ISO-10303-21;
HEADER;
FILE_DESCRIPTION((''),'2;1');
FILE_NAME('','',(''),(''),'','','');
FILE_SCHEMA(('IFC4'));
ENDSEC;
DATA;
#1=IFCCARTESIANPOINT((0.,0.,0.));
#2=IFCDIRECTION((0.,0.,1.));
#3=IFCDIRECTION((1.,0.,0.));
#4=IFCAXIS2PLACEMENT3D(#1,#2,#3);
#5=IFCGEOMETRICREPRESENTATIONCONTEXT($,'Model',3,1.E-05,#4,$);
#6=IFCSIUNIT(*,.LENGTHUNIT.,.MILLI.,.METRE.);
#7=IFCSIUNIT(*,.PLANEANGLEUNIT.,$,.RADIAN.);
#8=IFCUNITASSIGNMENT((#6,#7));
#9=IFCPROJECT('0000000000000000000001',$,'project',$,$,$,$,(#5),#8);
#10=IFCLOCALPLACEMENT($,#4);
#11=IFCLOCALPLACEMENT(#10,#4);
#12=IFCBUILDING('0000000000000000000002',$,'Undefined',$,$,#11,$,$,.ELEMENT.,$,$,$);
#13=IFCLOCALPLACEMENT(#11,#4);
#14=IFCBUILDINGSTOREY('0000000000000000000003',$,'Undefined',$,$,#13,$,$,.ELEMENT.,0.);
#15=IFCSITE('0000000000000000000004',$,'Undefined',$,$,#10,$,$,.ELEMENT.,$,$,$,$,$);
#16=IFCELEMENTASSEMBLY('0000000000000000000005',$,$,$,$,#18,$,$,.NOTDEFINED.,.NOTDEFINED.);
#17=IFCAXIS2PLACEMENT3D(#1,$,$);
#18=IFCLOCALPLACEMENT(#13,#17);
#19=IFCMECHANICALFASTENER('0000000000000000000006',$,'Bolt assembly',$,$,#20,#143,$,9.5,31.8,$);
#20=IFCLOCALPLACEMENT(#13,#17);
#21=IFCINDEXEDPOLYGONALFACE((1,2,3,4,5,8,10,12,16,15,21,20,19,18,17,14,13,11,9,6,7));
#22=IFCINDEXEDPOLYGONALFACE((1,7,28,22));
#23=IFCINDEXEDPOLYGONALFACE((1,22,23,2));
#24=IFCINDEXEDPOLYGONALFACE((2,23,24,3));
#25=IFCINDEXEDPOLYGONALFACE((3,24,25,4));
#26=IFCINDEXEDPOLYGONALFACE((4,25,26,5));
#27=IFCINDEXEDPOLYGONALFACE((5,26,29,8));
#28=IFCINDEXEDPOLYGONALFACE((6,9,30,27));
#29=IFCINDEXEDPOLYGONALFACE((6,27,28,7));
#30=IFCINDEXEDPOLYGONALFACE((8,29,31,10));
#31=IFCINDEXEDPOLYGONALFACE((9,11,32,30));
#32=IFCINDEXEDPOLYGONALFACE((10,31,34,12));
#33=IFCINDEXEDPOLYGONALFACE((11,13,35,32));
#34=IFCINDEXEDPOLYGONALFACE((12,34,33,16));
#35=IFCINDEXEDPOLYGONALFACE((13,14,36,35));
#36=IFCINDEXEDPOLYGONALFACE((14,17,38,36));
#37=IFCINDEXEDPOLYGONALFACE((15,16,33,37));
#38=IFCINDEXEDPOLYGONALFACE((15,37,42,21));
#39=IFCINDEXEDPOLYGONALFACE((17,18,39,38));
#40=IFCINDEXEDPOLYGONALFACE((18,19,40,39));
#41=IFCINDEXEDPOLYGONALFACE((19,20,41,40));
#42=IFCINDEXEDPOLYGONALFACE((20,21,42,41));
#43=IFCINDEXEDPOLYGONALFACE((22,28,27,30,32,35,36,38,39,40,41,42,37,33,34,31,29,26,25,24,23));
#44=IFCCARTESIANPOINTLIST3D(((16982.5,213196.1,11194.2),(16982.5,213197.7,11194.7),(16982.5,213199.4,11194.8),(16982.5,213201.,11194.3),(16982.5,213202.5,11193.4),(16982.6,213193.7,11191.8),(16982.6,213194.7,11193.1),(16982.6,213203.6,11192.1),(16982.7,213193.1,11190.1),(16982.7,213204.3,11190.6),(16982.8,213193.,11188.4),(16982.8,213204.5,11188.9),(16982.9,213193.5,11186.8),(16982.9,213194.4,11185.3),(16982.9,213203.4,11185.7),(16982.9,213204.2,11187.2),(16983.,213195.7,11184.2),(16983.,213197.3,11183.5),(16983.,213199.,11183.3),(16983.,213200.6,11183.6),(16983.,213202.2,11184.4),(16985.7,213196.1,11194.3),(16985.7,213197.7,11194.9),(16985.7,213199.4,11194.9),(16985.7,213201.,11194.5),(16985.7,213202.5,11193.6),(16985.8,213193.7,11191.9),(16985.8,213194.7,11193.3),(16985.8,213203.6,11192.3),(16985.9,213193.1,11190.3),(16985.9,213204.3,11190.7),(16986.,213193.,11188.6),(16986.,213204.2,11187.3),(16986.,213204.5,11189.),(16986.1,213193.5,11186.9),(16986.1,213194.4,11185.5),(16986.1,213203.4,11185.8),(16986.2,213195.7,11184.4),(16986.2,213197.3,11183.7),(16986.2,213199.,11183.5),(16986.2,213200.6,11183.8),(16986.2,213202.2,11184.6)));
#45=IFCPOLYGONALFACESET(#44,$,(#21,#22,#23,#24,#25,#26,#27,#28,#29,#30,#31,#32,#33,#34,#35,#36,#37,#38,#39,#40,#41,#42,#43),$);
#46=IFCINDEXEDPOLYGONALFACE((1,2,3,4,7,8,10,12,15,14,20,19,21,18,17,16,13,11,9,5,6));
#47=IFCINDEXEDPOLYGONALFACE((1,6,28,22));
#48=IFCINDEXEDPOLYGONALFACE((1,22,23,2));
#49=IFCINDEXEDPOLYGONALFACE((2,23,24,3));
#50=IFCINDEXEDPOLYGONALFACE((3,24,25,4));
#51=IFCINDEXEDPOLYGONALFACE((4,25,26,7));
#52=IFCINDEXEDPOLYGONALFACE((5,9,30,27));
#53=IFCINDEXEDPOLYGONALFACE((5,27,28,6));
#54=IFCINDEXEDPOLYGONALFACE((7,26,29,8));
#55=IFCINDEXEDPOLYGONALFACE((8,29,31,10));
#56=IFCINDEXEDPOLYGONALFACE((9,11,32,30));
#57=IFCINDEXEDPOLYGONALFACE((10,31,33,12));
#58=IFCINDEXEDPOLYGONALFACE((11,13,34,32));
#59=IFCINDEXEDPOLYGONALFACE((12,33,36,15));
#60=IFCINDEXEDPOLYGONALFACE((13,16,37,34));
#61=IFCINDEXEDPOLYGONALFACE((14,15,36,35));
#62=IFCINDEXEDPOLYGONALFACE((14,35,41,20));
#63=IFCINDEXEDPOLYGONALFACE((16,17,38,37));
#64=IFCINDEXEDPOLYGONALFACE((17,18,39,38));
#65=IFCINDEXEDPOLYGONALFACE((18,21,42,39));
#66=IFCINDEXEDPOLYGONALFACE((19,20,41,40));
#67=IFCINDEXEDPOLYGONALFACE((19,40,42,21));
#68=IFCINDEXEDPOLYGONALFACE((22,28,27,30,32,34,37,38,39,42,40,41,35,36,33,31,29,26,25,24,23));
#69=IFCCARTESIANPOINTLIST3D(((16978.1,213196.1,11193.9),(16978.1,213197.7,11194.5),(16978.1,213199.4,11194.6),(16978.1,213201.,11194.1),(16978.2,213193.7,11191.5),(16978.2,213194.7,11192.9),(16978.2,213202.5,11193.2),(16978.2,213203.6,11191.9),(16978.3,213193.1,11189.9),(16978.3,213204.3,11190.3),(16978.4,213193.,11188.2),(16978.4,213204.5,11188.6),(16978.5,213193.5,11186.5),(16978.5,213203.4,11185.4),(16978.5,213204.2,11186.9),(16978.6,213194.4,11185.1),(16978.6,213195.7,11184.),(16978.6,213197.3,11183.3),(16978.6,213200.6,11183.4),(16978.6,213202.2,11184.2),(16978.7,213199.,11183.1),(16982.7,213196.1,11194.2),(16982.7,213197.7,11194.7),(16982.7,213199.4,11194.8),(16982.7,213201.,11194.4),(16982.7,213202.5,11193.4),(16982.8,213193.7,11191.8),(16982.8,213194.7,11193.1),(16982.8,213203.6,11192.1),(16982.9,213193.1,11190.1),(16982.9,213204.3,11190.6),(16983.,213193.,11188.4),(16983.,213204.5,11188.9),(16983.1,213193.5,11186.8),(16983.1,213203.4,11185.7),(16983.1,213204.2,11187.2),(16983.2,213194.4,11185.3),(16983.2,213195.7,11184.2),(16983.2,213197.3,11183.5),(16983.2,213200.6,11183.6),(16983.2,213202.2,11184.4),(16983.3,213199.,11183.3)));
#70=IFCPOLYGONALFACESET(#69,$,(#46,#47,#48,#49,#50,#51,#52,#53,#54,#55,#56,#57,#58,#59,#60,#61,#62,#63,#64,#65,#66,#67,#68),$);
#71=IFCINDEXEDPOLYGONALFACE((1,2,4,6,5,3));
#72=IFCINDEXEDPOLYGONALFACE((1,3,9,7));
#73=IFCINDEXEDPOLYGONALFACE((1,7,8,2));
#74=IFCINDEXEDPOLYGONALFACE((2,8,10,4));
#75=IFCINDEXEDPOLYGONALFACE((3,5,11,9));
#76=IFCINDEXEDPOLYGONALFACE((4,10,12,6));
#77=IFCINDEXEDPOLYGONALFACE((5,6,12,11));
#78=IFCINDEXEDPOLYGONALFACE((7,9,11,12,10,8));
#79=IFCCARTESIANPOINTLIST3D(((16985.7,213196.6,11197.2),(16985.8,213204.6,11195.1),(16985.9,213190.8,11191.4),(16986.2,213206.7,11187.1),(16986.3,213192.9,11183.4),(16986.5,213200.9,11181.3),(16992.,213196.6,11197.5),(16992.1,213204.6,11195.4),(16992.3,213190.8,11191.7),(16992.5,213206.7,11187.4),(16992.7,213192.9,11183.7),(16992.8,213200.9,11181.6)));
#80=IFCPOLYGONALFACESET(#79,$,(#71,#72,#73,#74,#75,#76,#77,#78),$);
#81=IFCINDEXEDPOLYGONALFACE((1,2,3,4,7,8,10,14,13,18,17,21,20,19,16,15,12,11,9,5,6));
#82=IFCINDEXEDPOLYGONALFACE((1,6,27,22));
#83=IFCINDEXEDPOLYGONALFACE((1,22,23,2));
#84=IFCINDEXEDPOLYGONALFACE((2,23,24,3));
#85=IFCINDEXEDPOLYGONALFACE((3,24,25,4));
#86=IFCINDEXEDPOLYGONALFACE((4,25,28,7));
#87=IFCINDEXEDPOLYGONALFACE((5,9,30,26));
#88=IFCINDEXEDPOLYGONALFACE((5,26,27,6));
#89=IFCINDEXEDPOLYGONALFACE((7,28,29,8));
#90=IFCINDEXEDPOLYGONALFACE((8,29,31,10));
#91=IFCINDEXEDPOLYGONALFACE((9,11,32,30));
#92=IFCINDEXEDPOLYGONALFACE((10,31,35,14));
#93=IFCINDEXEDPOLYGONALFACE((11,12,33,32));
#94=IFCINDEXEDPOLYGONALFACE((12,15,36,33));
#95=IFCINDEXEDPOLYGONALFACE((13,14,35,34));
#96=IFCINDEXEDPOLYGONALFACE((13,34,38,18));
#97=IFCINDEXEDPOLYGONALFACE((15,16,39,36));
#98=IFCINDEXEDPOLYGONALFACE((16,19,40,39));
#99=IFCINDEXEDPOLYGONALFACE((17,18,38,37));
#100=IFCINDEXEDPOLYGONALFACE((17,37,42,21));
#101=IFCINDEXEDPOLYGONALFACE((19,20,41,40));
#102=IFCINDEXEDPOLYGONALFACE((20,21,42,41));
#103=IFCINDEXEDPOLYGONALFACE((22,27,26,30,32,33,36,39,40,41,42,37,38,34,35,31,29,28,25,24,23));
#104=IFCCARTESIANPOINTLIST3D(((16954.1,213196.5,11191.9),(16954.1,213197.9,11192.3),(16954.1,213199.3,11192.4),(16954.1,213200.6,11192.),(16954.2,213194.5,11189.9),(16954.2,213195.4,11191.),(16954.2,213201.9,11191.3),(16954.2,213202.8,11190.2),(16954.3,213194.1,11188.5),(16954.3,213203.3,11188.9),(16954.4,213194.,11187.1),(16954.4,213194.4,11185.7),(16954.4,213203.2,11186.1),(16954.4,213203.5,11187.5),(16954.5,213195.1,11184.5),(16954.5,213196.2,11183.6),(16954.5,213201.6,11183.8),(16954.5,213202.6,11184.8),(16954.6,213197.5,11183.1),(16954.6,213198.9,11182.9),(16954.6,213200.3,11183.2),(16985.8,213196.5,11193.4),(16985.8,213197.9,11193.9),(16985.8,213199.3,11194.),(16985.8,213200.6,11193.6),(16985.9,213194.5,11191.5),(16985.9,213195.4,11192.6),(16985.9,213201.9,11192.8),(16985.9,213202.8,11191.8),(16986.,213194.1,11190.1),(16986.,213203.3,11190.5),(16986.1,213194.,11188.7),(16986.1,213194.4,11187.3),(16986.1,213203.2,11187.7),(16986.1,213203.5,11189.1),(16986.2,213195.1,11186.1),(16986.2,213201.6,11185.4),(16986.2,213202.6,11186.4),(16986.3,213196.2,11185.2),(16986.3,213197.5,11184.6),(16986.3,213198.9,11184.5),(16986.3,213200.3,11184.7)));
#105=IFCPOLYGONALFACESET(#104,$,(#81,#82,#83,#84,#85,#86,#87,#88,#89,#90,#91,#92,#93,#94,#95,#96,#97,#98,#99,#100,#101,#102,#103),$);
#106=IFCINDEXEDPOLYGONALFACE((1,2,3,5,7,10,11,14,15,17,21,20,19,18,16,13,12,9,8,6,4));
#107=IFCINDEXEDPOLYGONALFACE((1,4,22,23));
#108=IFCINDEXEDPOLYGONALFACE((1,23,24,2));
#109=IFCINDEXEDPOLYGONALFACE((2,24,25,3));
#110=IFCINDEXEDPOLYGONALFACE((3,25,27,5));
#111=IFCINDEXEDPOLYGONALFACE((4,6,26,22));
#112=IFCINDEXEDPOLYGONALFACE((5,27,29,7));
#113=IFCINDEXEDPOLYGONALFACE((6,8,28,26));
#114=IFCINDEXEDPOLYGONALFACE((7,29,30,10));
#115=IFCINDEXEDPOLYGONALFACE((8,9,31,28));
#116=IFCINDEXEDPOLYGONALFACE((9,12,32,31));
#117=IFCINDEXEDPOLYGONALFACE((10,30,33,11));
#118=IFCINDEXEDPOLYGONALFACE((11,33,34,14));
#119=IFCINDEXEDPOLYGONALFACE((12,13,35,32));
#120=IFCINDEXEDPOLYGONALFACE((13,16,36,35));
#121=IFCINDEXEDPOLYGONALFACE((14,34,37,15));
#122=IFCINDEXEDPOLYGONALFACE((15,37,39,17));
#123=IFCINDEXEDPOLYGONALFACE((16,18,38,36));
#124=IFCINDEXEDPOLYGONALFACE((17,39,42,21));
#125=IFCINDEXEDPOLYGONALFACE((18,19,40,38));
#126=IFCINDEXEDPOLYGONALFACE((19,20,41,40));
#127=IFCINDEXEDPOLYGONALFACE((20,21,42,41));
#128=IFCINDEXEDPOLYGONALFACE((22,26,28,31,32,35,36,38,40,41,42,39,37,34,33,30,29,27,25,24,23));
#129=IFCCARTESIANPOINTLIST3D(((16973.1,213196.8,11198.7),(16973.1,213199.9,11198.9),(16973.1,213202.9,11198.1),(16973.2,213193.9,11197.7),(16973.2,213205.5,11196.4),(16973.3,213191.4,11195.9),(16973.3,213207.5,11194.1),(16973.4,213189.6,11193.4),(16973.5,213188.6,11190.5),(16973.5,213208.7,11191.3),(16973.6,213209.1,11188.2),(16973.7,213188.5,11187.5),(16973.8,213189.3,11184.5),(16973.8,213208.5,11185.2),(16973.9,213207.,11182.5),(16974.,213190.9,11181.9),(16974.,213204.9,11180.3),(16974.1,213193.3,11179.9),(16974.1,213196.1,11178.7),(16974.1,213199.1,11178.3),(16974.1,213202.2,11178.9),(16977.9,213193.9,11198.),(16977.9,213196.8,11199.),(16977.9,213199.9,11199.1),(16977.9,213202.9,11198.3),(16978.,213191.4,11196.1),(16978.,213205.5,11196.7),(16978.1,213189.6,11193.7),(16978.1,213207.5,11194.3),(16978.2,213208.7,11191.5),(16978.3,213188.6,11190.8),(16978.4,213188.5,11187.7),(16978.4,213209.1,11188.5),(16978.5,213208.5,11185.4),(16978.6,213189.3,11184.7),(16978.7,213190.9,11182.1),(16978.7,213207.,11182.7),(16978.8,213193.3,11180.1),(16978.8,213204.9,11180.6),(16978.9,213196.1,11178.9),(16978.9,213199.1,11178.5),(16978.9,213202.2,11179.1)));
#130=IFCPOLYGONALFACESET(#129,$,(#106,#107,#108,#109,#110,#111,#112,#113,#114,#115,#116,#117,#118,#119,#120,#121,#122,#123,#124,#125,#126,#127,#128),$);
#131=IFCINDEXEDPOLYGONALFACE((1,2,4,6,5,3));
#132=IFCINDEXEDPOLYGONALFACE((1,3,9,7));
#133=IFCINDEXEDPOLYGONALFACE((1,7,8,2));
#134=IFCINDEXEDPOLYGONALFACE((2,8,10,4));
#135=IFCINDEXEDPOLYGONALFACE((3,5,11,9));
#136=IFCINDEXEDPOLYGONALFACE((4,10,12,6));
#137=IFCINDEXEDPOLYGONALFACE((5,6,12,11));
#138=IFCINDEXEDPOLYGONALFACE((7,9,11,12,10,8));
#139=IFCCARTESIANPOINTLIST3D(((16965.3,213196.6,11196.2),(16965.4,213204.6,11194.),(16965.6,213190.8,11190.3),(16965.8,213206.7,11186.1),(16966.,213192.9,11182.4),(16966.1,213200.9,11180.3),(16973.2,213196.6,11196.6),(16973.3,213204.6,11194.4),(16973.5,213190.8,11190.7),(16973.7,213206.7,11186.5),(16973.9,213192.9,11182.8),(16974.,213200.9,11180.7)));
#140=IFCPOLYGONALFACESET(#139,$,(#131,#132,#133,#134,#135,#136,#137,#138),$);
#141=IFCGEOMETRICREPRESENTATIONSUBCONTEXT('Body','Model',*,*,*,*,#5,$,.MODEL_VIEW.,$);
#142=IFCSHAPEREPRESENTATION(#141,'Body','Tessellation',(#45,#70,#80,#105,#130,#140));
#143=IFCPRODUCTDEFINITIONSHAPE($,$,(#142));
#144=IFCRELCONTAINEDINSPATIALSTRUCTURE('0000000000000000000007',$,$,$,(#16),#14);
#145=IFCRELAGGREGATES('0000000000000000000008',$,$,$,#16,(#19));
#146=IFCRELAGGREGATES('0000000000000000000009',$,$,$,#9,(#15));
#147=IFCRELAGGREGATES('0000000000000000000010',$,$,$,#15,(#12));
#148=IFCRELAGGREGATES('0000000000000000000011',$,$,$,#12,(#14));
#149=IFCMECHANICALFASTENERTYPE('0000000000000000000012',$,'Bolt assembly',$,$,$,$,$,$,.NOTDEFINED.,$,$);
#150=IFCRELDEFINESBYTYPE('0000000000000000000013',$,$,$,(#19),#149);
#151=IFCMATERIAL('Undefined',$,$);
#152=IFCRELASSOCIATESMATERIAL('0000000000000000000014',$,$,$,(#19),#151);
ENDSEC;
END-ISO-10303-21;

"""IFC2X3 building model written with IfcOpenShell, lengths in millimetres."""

from ifc_helpers import new_model, si_unit, frame, origin_with_axes, origin_2d_with_axis, place, context, subcontext, project, spatial, polyline, circle, outline, extrude, source, transform, mapped, material, type_object, element, aggregate, save


model = new_model("IFC2X3")

# Units and contexts
model_context = context("Model", 3, precision=1e-05, world=origin_with_axes())
body_context = subcontext(model_context, "Body", "Model", "MODEL_VIEW")
ifc_project = project(units=[si_unit("LENGTHUNIT", "METRE", prefix="MILLI"), si_unit("PLANEANGLEUNIT", "RADIAN")], contexts=[model_context])

# Site, building, storey
site_placement = place(None, origin_with_axes())
site = spatial("IfcSite", under=ifc_project, at=site_placement, Name="Undefined", CompositionType="ELEMENT")
building_placement = place(site_placement, origin_with_axes())
building = spatial("IfcBuilding", under=site, at=building_placement, Name="Undefined", CompositionType="ELEMENT")
storey_placement = place(building_placement, origin_with_axes())
storey = spatial("IfcBuildingStorey", under=building, at=storey_placement, Name="Undefined", CompositionType="ELEMENT", Elevation=0.0)

# Element assembly
assembly_1_placement = place(storey_placement, origin_with_axes())
assembly_1 = element("IfcElementAssembly", 1, at=assembly_1_placement, inside=storey, AssemblyPlace="NOTDEFINED", PredefinedType="NOTDEFINED")

# Mechanical fastener
ifc_material_1 = material(Name="Undefined")
mechanical_fastener_type = type_object("IfcMechanicalFastenerType", Name="Bolt assembly")
shared_shape_1 = source(origin_with_axes(), body_context, "Body", "SweptSolid", [
    extrude(circle(Radius=5.8, at=origin_2d_with_axis()), frame((0.0, -7.6, 0.0), z_axis=(0.0, 1.0, 0.0), x_axis=(1.0, 0.0, 0.0)), (0.0, 0.0, 1.0), 3.2),
    extrude(circle(Radius=5.8, at=origin_2d_with_axis()), frame((0.0, -4.6, 0.0), z_axis=(0.0, 1.0, 0.0), x_axis=(1.0, 0.0, 0.0)), (0.0, 0.0, 1.0), 4.6),
    extrude(outline(polyline([(7.1, -4.1), (7.1, 4.1), (0.0, 8.2), (-7.1, 4.1), (-7.1, -4.1), (0.0, -8.2), (7.1, -4.1)])), frame((0.0, -14.0, 0.0), z_axis=(0.0, 1.0, 0.0), x_axis=(1.0, 0.0, 0.0)), (0.0, 0.0, 1.0), 6.3),
    extrude(circle(Radius=4.8, at=origin_2d_with_axis()), frame((0.0, -7.7, 0.0), z_axis=(0.0, 1.0, 0.0), x_axis=(1.0, 0.0, 0.0)), (0.0, 0.0, 1.0), 31.8),
    extrude(circle(Radius=10.3, at=origin_2d_with_axis()), frame((0.0, 0.0, 0.0), z_axis=(0.0, 1.0, 0.0), x_axis=(1.0, 0.0, 0.0)), (0.0, 0.0, 1.0), 4.8),
    extrude(outline(polyline([(7.1, -4.1), (7.1, 4.1), (0.0, 8.2), (-7.1, 4.1), (-7.1, -4.1), (0.0, -8.2), (7.1, -4.1)])), frame((0.0, 4.8, 0.0), z_axis=(0.0, 1.0, 0.0), x_axis=(1.0, 0.0, 0.0)), (0.0, 0.0, 1.0), 7.9),
])
mechanical_fastener_1_placement = place(assembly_1_placement, frame((16978.4, 213198.7, 11188.8), z_axis=(0.035281, -0.707107, -0.706226), x_axis=(-0.035281, -0.707107, 0.706226)))
mechanical_fastener_1 = element("IfcMechanicalFastener", 2, at=mechanical_fastener_1_placement, type_object=mechanical_fastener_type, material=ifc_material_1, Name="Bolt assembly", NominalDiameter=9.5, NominalLength=31.8, context=body_context, shape_type="MappedRepresentation", body=[
    mapped(shared_shape_1, transform((0.0, 0.0, 0.0))),
])
aggregate(assembly_1, [mechanical_fastener_1])

save(model, "model.ifc")
